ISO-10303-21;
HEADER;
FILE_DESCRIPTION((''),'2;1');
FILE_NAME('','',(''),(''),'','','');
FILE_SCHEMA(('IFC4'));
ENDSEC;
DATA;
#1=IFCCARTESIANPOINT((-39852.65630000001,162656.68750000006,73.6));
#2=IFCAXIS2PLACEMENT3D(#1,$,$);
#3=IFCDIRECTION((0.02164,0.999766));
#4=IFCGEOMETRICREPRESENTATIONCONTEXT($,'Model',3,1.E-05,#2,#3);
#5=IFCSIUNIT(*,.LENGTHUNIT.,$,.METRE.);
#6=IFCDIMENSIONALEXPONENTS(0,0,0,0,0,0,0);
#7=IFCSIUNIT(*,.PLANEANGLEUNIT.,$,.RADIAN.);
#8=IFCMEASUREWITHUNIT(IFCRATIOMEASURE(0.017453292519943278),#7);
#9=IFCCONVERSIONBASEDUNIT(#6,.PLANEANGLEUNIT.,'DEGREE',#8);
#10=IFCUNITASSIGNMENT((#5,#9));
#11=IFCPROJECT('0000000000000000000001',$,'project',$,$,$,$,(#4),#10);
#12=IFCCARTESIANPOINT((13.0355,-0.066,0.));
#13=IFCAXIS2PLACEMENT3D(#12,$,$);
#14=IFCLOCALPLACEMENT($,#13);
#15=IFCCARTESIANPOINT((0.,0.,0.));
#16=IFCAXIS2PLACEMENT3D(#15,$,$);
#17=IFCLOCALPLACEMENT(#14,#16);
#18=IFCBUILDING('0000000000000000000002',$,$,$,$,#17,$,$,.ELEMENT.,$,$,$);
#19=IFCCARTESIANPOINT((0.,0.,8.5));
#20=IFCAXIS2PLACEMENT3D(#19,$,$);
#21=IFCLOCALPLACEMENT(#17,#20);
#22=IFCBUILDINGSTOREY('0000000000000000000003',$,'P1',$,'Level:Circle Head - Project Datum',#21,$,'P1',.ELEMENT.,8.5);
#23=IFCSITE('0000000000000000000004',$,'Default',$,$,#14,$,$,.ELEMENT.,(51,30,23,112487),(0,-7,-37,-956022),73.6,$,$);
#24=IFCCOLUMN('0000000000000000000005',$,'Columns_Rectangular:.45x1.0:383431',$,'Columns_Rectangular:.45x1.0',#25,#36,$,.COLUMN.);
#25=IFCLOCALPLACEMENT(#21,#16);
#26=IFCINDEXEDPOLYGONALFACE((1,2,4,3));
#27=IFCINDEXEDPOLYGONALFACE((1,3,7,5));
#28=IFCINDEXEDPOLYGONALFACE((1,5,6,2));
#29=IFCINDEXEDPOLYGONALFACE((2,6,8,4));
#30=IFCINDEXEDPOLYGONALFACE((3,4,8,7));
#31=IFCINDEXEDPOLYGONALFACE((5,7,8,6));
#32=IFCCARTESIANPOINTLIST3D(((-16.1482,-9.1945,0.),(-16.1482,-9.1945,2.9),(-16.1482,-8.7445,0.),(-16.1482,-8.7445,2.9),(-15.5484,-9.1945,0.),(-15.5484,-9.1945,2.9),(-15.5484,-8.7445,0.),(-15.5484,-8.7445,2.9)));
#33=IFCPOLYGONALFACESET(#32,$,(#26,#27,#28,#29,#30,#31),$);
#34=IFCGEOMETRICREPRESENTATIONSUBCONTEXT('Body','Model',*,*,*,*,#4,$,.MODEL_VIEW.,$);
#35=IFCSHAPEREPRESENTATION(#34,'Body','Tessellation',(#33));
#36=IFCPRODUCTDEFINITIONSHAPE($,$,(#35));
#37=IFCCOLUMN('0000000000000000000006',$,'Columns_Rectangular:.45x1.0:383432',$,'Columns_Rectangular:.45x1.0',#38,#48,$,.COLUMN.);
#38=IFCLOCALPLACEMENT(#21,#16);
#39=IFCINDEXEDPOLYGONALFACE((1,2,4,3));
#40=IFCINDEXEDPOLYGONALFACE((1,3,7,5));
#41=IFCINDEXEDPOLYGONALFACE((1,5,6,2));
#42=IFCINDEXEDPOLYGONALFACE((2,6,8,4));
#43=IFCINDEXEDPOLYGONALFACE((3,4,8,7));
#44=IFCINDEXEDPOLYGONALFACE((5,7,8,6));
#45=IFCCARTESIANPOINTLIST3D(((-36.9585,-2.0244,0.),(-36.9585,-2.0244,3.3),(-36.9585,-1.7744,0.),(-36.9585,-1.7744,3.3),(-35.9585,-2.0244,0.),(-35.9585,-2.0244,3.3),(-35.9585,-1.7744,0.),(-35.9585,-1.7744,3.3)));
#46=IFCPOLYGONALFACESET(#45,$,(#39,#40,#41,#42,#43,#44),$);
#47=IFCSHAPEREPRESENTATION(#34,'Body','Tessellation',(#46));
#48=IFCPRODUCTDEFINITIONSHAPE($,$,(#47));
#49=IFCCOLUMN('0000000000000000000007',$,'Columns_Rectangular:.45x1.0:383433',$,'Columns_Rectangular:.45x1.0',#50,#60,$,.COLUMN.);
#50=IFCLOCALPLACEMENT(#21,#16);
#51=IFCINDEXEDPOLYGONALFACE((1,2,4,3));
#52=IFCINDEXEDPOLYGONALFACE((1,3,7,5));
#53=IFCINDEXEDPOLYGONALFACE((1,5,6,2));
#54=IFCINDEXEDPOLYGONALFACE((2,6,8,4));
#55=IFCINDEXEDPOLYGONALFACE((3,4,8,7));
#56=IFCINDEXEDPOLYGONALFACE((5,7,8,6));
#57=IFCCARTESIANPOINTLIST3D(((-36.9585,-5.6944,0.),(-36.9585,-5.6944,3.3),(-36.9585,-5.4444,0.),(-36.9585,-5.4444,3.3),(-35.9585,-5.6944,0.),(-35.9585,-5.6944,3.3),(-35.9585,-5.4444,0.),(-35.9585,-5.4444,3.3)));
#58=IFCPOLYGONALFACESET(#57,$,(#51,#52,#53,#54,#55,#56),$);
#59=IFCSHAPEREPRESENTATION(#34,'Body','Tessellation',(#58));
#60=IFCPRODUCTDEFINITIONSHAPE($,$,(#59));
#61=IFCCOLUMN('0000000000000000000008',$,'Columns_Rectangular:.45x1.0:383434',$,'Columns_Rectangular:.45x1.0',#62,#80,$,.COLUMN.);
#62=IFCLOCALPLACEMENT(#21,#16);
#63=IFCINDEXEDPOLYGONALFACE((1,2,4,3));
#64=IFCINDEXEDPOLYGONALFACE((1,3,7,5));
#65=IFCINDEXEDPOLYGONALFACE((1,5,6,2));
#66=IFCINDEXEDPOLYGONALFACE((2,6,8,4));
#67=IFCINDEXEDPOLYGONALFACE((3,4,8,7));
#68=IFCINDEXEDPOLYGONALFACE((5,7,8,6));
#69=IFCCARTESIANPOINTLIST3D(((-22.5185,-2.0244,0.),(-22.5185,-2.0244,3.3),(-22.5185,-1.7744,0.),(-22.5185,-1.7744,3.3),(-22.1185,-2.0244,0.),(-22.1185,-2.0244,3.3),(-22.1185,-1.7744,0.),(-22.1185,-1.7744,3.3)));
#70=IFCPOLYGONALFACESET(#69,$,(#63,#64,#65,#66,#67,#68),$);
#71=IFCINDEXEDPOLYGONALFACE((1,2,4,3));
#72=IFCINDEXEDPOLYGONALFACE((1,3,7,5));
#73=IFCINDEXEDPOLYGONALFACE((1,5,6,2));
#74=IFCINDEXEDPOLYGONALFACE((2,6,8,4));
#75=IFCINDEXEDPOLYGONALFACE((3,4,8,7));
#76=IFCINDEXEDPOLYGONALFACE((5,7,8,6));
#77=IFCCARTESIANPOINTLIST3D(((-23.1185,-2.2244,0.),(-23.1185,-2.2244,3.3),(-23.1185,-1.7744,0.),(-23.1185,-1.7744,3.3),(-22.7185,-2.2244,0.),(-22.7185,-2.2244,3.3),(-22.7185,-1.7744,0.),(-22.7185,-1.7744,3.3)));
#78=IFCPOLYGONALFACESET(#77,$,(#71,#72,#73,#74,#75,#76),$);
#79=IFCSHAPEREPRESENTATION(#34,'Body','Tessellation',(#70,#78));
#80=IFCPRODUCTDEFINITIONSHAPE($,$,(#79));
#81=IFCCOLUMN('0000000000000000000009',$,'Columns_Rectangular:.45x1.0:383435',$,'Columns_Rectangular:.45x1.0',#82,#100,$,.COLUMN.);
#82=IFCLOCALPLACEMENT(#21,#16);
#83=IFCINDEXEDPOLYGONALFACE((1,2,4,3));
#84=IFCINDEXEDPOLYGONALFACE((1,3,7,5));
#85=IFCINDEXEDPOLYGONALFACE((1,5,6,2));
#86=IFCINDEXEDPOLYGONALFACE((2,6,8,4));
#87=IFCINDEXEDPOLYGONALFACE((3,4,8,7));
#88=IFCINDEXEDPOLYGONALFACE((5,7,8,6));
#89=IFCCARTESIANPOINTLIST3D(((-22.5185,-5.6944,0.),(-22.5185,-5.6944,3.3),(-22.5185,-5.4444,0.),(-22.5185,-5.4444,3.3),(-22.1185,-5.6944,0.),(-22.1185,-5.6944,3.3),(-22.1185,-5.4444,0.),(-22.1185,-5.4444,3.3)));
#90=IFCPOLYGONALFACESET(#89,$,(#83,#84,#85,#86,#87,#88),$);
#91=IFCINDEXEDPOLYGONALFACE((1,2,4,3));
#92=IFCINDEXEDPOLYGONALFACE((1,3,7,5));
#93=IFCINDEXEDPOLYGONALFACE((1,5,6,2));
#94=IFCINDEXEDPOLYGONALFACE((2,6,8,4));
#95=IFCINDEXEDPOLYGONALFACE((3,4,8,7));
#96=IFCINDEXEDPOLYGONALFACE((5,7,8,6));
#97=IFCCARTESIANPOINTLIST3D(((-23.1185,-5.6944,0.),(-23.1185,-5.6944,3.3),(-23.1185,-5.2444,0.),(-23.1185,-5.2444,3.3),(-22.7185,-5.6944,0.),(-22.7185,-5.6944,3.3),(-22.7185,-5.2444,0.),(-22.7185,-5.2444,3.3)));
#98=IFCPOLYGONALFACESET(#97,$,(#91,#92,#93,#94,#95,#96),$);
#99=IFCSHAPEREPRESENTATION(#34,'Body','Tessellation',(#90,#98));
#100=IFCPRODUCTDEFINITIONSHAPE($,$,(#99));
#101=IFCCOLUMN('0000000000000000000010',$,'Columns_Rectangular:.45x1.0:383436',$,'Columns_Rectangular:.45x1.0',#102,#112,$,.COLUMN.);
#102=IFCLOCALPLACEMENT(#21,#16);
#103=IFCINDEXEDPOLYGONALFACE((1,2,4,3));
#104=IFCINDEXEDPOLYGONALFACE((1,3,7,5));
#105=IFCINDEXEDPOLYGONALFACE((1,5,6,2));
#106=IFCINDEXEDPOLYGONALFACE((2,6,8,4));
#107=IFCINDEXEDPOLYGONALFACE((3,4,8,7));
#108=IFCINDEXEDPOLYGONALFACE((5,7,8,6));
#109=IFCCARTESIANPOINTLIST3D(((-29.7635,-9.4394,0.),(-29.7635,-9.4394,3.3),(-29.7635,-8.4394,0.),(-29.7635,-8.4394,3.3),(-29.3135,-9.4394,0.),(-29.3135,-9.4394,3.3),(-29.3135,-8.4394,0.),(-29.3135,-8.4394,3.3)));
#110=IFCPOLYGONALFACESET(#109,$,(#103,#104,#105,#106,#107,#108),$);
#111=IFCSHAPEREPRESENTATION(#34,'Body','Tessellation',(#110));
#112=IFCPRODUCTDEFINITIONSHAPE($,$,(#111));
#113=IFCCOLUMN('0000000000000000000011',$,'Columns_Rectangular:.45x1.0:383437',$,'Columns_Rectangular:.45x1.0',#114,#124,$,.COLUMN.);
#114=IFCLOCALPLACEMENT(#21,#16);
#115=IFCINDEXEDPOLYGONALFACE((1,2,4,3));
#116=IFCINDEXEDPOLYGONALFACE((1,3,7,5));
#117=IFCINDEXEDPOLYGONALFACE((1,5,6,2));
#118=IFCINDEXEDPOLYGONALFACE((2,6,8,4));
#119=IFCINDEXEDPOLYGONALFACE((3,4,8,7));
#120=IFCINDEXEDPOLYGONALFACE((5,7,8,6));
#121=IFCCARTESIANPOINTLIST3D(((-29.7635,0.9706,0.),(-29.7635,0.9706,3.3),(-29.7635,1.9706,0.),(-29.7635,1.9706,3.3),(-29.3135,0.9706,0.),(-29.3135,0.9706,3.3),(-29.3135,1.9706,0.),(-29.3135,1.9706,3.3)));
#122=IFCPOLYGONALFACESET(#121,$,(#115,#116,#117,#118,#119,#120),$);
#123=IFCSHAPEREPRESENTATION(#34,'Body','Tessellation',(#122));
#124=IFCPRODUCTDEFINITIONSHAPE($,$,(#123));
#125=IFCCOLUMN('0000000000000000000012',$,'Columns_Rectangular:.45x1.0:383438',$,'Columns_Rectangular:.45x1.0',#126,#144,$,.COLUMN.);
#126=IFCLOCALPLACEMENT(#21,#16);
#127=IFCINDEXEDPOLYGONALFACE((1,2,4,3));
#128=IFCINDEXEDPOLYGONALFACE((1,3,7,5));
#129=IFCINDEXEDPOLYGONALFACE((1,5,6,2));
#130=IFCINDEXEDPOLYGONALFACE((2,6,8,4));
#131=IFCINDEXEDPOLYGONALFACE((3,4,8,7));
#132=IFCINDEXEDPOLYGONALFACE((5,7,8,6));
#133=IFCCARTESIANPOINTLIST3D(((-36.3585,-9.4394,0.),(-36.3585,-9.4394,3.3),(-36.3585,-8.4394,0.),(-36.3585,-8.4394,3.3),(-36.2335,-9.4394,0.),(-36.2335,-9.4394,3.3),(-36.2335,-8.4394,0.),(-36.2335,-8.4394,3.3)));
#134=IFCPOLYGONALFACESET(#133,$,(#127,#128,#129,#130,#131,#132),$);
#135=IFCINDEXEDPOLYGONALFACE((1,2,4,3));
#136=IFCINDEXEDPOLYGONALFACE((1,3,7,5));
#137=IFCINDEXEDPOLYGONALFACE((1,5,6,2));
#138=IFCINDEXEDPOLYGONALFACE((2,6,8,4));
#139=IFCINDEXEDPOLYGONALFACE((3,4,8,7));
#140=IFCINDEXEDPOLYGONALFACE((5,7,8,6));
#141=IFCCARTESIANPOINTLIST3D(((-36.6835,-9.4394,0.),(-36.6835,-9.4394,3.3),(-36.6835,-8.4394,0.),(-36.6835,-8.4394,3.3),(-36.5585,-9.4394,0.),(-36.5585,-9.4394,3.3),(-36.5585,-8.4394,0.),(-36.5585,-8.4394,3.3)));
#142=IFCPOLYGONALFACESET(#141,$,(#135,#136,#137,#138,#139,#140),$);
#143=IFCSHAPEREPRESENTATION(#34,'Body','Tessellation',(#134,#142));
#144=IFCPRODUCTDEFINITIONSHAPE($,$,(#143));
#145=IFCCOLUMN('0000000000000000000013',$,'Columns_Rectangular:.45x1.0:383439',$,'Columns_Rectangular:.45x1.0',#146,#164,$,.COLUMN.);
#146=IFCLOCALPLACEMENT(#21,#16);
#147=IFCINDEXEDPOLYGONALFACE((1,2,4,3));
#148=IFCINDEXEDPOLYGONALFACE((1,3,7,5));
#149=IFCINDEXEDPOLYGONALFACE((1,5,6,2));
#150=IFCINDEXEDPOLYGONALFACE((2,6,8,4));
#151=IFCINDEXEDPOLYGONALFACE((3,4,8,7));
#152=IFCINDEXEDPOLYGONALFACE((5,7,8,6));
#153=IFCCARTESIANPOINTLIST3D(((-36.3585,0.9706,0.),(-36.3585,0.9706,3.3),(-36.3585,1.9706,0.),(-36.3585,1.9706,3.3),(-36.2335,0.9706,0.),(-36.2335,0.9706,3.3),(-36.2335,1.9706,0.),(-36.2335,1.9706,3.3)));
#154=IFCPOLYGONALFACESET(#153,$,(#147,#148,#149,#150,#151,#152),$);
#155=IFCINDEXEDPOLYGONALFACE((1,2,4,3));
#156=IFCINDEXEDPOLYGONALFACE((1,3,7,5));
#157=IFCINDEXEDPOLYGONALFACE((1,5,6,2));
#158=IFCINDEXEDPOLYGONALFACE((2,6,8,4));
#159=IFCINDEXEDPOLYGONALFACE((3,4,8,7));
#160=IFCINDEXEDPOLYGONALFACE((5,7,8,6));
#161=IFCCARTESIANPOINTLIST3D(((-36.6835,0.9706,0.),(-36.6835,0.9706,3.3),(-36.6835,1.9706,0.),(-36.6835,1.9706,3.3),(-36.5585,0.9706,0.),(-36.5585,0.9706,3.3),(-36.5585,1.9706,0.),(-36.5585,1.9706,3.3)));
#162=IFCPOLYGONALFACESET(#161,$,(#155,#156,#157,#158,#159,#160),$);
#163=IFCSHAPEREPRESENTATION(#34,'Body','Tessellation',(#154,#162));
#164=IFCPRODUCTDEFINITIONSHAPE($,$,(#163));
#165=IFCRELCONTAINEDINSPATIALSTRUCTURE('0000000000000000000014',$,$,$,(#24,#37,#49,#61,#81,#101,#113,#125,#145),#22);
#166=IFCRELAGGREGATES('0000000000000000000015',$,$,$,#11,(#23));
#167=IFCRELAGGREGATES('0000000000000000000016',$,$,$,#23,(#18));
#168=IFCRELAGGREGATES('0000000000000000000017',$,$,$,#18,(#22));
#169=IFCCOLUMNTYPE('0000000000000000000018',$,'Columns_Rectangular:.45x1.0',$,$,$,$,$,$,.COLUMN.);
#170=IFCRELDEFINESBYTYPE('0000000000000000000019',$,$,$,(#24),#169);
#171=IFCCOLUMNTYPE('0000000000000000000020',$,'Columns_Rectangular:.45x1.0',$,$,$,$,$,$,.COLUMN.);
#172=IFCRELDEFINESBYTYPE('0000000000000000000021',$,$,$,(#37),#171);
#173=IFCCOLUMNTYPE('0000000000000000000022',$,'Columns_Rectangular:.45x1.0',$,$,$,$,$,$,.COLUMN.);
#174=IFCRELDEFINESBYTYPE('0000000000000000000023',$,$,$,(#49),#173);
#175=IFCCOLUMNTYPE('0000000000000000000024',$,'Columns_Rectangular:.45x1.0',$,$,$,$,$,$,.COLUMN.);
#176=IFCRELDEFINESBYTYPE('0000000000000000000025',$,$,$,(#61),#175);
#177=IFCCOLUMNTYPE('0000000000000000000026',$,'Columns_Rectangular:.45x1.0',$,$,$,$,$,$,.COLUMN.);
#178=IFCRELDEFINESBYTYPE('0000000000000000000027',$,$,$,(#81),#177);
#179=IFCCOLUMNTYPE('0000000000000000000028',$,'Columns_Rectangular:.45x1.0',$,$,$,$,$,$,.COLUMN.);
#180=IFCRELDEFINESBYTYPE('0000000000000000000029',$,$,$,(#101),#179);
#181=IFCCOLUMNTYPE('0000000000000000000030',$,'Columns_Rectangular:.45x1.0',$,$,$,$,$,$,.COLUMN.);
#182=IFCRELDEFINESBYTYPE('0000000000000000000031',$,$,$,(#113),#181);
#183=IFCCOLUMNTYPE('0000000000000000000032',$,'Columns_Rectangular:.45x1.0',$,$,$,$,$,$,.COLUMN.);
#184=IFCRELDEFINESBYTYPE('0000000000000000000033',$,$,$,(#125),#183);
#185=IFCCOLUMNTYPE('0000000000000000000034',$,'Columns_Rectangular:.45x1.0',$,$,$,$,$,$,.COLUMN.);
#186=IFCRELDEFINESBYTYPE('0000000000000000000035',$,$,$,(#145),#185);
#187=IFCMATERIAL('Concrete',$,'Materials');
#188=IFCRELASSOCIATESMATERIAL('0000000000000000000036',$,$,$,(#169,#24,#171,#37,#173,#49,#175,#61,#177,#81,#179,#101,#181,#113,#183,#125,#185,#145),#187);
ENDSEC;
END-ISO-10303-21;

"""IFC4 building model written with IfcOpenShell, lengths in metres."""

from ifc_helpers import new_model, entity, si_unit, converted_unit, direction, frame, origin, place, context, subcontext, project, spatial, indexed_curve, outline, extrude, source, transform, mapped, material, type_object, type_shapes, element, save


model = new_model("IFC4")

# Units and contexts
model_context = context("Model", 3, precision=1e-05, world=frame((-39852.65630000001, 162656.68750000006, 73.6)), true_north=direction((0.02164, 0.999766)))
body_context = subcontext(model_context, "Body", "Model", "MODEL_VIEW")
ifc_project = project(units=[si_unit("LENGTHUNIT", "METRE"), converted_unit("PLANEANGLEUNIT", "DEGREE", entity("IfcRatioMeasure", 0.017453292519943278), si_unit("PLANEANGLEUNIT", "RADIAN"), dimensions=[0, 0, 0, 0, 0, 0, 0])], contexts=[model_context])

# Site, building, storey
site_placement = place(None, frame((13.0355, -0.066, 0.0)))
site = spatial("IfcSite", under=ifc_project, at=site_placement, Name="Default", CompositionType="ELEMENT", RefLatitude=(51, 30, 23, 112487), RefLongitude=(0, -7, -37, -956022), RefElevation=73.6)
building_placement = place(site_placement, origin())
building = spatial("IfcBuilding", under=site, at=building_placement, CompositionType="ELEMENT")
storey_placement = place(building_placement, frame((0.0, 0.0, 8.5)))
storey = spatial("IfcBuildingStorey", under=building, at=storey_placement, Name="P1", ObjectType="Level:Circle Head - Project Datum", LongName="P1", CompositionType="ELEMENT", Elevation=8.5)

# Columns
ifc_material = material(Name="Concrete", Category="Materials")
column_type_1 = type_object("IfcColumnType", Name="Columns_Rectangular:.45x1.0", PredefinedType="COLUMN", material=ifc_material)
shared_shape_1 = source(origin(), body_context, "Body", "SweptSolid", [
    extrude(outline(indexed_curve([(-0.225, -0.2999), (0.225, -0.2999), (0.225, 0.2999), (-0.225, 0.2999), (-0.225, -0.2999)], self_intersect=False)), frame((-15.8483, -8.9695, 8.5), z_axis=(0.0, 0.0, 1.0), x_axis=(0.0, -1.0, 0.0)), (0.0, 0.0, 1.0), 2.9),
])
type_shapes(column_type_1, [shared_shape_1])
column_1_placement = place(storey_placement, frame((0.0, 0.0, -8.5)))
element("IfcColumn", 1, at=column_1_placement, inside=storey, type_object=column_type_1, material=ifc_material, Name="Columns_Rectangular:.45x1.0:383431", ObjectType="Columns_Rectangular:.45x1.0", PredefinedType="COLUMN", context=body_context, shape_type="MappedRepresentation", body=[
    mapped(shared_shape_1, transform((0.0, 0.0, 0.0), scale=1.0)),
])
column_type_2 = type_object("IfcColumnType", Name="Columns_Rectangular:.45x1.0", PredefinedType="COLUMN", material=ifc_material)
shared_shape_2 = source(origin(), body_context, "Body", "SweptSolid", [
    extrude(outline(indexed_curve([(-0.125, -0.5), (0.125, -0.5), (0.125, 0.5), (-0.125, 0.5), (-0.125, -0.5)], self_intersect=False)), frame((-36.4585, -1.8994, 8.5), z_axis=(0.0, 0.0, 1.0), x_axis=(0.0, -1.0, 0.0)), (0.0, 0.0, 1.0), 3.3),
])
type_shapes(column_type_2, [shared_shape_2])
column_2_placement = place(storey_placement, frame((0.0, 0.0, -8.5)))
element("IfcColumn", 2, at=column_2_placement, inside=storey, type_object=column_type_2, material=ifc_material, Name="Columns_Rectangular:.45x1.0:383432", ObjectType="Columns_Rectangular:.45x1.0", PredefinedType="COLUMN", context=body_context, shape_type="MappedRepresentation", body=[
    mapped(shared_shape_2, transform((0.0, 0.0, 0.0), scale=1.0)),
])
column_type_3 = type_object("IfcColumnType", Name="Columns_Rectangular:.45x1.0", PredefinedType="COLUMN", material=ifc_material)
shared_shape_3 = source(origin(), body_context, "Body", "SweptSolid", [
    extrude(outline(indexed_curve([(-0.125, -0.5), (0.125, -0.5), (0.125, 0.5), (-0.125, 0.5), (-0.125, -0.5)], self_intersect=False)), frame((-36.4585, -5.5694, 8.5), z_axis=(0.0, 0.0, 1.0), x_axis=(0.0, -1.0, 0.0)), (0.0, 0.0, 1.0), 3.3),
])
type_shapes(column_type_3, [shared_shape_3])
column_3_placement = place(storey_placement, frame((0.0, 0.0, -8.5)))
element("IfcColumn", 3, at=column_3_placement, inside=storey, type_object=column_type_3, material=ifc_material, Name="Columns_Rectangular:.45x1.0:383433", ObjectType="Columns_Rectangular:.45x1.0", PredefinedType="COLUMN", context=body_context, shape_type="MappedRepresentation", body=[
    mapped(shared_shape_3, transform((0.0, 0.0, 0.0), scale=1.0)),
])
column_type_4 = type_object("IfcColumnType", Name="Columns_Rectangular:.45x1.0", PredefinedType="COLUMN", material=ifc_material)
shared_shape_4 = source(origin(), body_context, "Body", "SweptSolid", [
    extrude(outline(indexed_curve([(-0.125, -0.2), (0.125, -0.2), (0.125, 0.2), (-0.125, 0.2), (-0.125, -0.2)], self_intersect=False)), frame((-22.3185, -1.8994, 8.5), z_axis=(0.0, 0.0, 1.0), x_axis=(0.0, -1.0, 0.0)), (0.0, 0.0, 1.0), 3.3),
    extrude(outline(indexed_curve([(-0.225, -0.2), (0.225, -0.2), (0.225, 0.2), (-0.225, 0.2), (-0.225, -0.2)], self_intersect=False)), frame((-22.9185, -1.9994, 8.5), z_axis=(0.0, 0.0, 1.0), x_axis=(0.0, -1.0, 0.0)), (0.0, 0.0, 1.0), 3.3),
])
type_shapes(column_type_4, [shared_shape_4])
column_4_placement = place(storey_placement, frame((0.0, 0.0, -8.5)))
element("IfcColumn", 4, at=column_4_placement, inside=storey, type_object=column_type_4, material=ifc_material, Name="Columns_Rectangular:.45x1.0:383434", ObjectType="Columns_Rectangular:.45x1.0", PredefinedType="COLUMN", context=body_context, shape_type="MappedRepresentation", body=[
    mapped(shared_shape_4, transform((0.0, 0.0, 0.0), scale=1.0)),
])
column_type_5 = type_object("IfcColumnType", Name="Columns_Rectangular:.45x1.0", PredefinedType="COLUMN", material=ifc_material)
shared_shape_5 = source(origin(), body_context, "Body", "SweptSolid", [
    extrude(outline(indexed_curve([(-0.125, -0.2), (0.125, -0.2), (0.125, 0.2), (-0.125, 0.2), (-0.125, -0.2)], self_intersect=False)), frame((-22.3185, -5.5694, 8.5), z_axis=(0.0, 0.0, 1.0), x_axis=(0.0, -1.0, 0.0)), (0.0, 0.0, 1.0), 3.3),
    extrude(outline(indexed_curve([(-0.225, -0.2), (0.225, -0.2), (0.225, 0.2), (-0.225, 0.2), (-0.225, -0.2)], self_intersect=False)), frame((-22.9185, -5.4694, 8.5), z_axis=(0.0, 0.0, 1.0), x_axis=(0.0, -1.0, 0.0)), (0.0, 0.0, 1.0), 3.3),
])
type_shapes(column_type_5, [shared_shape_5])
column_5_placement = place(storey_placement, frame((0.0, 0.0, -8.5)))
element("IfcColumn", 5, at=column_5_placement, inside=storey, type_object=column_type_5, material=ifc_material, Name="Columns_Rectangular:.45x1.0:383435", ObjectType="Columns_Rectangular:.45x1.0", PredefinedType="COLUMN", context=body_context, shape_type="MappedRepresentation", body=[
    mapped(shared_shape_5, transform((0.0, 0.0, 0.0), scale=1.0)),
])
column_type_6 = type_object("IfcColumnType", Name="Columns_Rectangular:.45x1.0", PredefinedType="COLUMN", material=ifc_material)
shared_shape_6 = source(origin(), body_context, "Body", "SweptSolid", [
    extrude(outline(indexed_curve([(-0.5, -0.225), (0.5, -0.225), (0.5, 0.225), (-0.5, 0.225), (-0.5, -0.225)], self_intersect=False)), frame((-29.5385, -8.9394, 8.5), z_axis=(0.0, 0.0, 1.0), x_axis=(0.0, -1.0, 0.0)), (0.0, 0.0, 1.0), 3.3),
])
type_shapes(column_type_6, [shared_shape_6])
column_6_placement = place(storey_placement, frame((0.0, 0.0, -8.5)))
element("IfcColumn", 6, at=column_6_placement, inside=storey, type_object=column_type_6, material=ifc_material, Name="Columns_Rectangular:.45x1.0:383436", ObjectType="Columns_Rectangular:.45x1.0", PredefinedType="COLUMN", context=body_context, shape_type="MappedRepresentation", body=[
    mapped(shared_shape_6, transform((0.0, 0.0, 0.0), scale=1.0)),
])
column_type_7 = type_object("IfcColumnType", Name="Columns_Rectangular:.45x1.0", PredefinedType="COLUMN", material=ifc_material)
shared_shape_7 = source(origin(), body_context, "Body", "SweptSolid", [
    extrude(outline(indexed_curve([(-0.5, -0.225), (0.5, -0.225), (0.5, 0.225), (-0.5, 0.225), (-0.5, -0.225)], self_intersect=False)), frame((-29.5385, 1.4706, 8.5), z_axis=(0.0, 0.0, 1.0), x_axis=(0.0, -1.0, 0.0)), (0.0, 0.0, 1.0), 3.3),
])
type_shapes(column_type_7, [shared_shape_7])
column_7_placement = place(storey_placement, frame((0.0, 0.0, -8.5)))
element("IfcColumn", 7, at=column_7_placement, inside=storey, type_object=column_type_7, material=ifc_material, Name="Columns_Rectangular:.45x1.0:383437", ObjectType="Columns_Rectangular:.45x1.0", PredefinedType="COLUMN", context=body_context, shape_type="MappedRepresentation", body=[
    mapped(shared_shape_7, transform((0.0, 0.0, 0.0), scale=1.0)),
])
column_type_8 = type_object("IfcColumnType", Name="Columns_Rectangular:.45x1.0", PredefinedType="COLUMN", material=ifc_material)
shared_shape_8 = source(origin(), body_context, "Body", "SweptSolid", [
    extrude(outline(indexed_curve([(-0.5, -0.0625), (0.5, -0.0625), (0.5, 0.0625), (-0.5, 0.0625), (-0.5, -0.0625)], self_intersect=False)), frame((-36.296, -8.9394, 8.5), z_axis=(0.0, 0.0, 1.0), x_axis=(0.0, -1.0, 0.0)), (0.0, 0.0, 1.0), 3.3),
    extrude(outline(indexed_curve([(-0.5, -0.0625), (0.5, -0.0625), (0.5, 0.0625), (-0.5, 0.0625), (-0.5, -0.0625)], self_intersect=False)), frame((-36.621, -8.9394, 8.5), z_axis=(0.0, 0.0, 1.0), x_axis=(0.0, -1.0, 0.0)), (0.0, 0.0, 1.0), 3.3),
])
type_shapes(column_type_8, [shared_shape_8])
column_8_placement = place(storey_placement, frame((0.0, 0.0, -8.5)))
element("IfcColumn", 8, at=column_8_placement, inside=storey, type_object=column_type_8, material=ifc_material, Name="Columns_Rectangular:.45x1.0:383438", ObjectType="Columns_Rectangular:.45x1.0", PredefinedType="COLUMN", context=body_context, shape_type="MappedRepresentation", body=[
    mapped(shared_shape_8, transform((0.0, 0.0, 0.0), scale=1.0)),
])
column_type_9 = type_object("IfcColumnType", Name="Columns_Rectangular:.45x1.0", PredefinedType="COLUMN", material=ifc_material)
shared_shape_9 = source(origin(), body_context, "Body", "SweptSolid", [
    extrude(outline(indexed_curve([(-0.5, -0.0625), (0.5, -0.0625), (0.5, 0.0625), (-0.5, 0.0625), (-0.5, -0.0625)], self_intersect=False)), frame((-36.296, 1.4706, 8.5), z_axis=(0.0, 0.0, 1.0), x_axis=(0.0, -1.0, 0.0)), (0.0, 0.0, 1.0), 3.3),
    extrude(outline(indexed_curve([(-0.5, -0.0625), (0.5, -0.0625), (0.5, 0.0625), (-0.5, 0.0625), (-0.5, -0.0625)], self_intersect=False)), frame((-36.621, 1.4706, 8.5), z_axis=(0.0, 0.0, 1.0), x_axis=(0.0, -1.0, 0.0)), (0.0, 0.0, 1.0), 3.3),
])
type_shapes(column_type_9, [shared_shape_9])
column_9_placement = place(storey_placement, frame((0.0, 0.0, -8.5)))
element("IfcColumn", 9, at=column_9_placement, inside=storey, type_object=column_type_9, material=ifc_material, Name="Columns_Rectangular:.45x1.0:383439", ObjectType="Columns_Rectangular:.45x1.0", PredefinedType="COLUMN", context=body_context, shape_type="MappedRepresentation", body=[
    mapped(shared_shape_9, transform((0.0, 0.0, 0.0), scale=1.0)),
])

save(model, "model.ifc")
